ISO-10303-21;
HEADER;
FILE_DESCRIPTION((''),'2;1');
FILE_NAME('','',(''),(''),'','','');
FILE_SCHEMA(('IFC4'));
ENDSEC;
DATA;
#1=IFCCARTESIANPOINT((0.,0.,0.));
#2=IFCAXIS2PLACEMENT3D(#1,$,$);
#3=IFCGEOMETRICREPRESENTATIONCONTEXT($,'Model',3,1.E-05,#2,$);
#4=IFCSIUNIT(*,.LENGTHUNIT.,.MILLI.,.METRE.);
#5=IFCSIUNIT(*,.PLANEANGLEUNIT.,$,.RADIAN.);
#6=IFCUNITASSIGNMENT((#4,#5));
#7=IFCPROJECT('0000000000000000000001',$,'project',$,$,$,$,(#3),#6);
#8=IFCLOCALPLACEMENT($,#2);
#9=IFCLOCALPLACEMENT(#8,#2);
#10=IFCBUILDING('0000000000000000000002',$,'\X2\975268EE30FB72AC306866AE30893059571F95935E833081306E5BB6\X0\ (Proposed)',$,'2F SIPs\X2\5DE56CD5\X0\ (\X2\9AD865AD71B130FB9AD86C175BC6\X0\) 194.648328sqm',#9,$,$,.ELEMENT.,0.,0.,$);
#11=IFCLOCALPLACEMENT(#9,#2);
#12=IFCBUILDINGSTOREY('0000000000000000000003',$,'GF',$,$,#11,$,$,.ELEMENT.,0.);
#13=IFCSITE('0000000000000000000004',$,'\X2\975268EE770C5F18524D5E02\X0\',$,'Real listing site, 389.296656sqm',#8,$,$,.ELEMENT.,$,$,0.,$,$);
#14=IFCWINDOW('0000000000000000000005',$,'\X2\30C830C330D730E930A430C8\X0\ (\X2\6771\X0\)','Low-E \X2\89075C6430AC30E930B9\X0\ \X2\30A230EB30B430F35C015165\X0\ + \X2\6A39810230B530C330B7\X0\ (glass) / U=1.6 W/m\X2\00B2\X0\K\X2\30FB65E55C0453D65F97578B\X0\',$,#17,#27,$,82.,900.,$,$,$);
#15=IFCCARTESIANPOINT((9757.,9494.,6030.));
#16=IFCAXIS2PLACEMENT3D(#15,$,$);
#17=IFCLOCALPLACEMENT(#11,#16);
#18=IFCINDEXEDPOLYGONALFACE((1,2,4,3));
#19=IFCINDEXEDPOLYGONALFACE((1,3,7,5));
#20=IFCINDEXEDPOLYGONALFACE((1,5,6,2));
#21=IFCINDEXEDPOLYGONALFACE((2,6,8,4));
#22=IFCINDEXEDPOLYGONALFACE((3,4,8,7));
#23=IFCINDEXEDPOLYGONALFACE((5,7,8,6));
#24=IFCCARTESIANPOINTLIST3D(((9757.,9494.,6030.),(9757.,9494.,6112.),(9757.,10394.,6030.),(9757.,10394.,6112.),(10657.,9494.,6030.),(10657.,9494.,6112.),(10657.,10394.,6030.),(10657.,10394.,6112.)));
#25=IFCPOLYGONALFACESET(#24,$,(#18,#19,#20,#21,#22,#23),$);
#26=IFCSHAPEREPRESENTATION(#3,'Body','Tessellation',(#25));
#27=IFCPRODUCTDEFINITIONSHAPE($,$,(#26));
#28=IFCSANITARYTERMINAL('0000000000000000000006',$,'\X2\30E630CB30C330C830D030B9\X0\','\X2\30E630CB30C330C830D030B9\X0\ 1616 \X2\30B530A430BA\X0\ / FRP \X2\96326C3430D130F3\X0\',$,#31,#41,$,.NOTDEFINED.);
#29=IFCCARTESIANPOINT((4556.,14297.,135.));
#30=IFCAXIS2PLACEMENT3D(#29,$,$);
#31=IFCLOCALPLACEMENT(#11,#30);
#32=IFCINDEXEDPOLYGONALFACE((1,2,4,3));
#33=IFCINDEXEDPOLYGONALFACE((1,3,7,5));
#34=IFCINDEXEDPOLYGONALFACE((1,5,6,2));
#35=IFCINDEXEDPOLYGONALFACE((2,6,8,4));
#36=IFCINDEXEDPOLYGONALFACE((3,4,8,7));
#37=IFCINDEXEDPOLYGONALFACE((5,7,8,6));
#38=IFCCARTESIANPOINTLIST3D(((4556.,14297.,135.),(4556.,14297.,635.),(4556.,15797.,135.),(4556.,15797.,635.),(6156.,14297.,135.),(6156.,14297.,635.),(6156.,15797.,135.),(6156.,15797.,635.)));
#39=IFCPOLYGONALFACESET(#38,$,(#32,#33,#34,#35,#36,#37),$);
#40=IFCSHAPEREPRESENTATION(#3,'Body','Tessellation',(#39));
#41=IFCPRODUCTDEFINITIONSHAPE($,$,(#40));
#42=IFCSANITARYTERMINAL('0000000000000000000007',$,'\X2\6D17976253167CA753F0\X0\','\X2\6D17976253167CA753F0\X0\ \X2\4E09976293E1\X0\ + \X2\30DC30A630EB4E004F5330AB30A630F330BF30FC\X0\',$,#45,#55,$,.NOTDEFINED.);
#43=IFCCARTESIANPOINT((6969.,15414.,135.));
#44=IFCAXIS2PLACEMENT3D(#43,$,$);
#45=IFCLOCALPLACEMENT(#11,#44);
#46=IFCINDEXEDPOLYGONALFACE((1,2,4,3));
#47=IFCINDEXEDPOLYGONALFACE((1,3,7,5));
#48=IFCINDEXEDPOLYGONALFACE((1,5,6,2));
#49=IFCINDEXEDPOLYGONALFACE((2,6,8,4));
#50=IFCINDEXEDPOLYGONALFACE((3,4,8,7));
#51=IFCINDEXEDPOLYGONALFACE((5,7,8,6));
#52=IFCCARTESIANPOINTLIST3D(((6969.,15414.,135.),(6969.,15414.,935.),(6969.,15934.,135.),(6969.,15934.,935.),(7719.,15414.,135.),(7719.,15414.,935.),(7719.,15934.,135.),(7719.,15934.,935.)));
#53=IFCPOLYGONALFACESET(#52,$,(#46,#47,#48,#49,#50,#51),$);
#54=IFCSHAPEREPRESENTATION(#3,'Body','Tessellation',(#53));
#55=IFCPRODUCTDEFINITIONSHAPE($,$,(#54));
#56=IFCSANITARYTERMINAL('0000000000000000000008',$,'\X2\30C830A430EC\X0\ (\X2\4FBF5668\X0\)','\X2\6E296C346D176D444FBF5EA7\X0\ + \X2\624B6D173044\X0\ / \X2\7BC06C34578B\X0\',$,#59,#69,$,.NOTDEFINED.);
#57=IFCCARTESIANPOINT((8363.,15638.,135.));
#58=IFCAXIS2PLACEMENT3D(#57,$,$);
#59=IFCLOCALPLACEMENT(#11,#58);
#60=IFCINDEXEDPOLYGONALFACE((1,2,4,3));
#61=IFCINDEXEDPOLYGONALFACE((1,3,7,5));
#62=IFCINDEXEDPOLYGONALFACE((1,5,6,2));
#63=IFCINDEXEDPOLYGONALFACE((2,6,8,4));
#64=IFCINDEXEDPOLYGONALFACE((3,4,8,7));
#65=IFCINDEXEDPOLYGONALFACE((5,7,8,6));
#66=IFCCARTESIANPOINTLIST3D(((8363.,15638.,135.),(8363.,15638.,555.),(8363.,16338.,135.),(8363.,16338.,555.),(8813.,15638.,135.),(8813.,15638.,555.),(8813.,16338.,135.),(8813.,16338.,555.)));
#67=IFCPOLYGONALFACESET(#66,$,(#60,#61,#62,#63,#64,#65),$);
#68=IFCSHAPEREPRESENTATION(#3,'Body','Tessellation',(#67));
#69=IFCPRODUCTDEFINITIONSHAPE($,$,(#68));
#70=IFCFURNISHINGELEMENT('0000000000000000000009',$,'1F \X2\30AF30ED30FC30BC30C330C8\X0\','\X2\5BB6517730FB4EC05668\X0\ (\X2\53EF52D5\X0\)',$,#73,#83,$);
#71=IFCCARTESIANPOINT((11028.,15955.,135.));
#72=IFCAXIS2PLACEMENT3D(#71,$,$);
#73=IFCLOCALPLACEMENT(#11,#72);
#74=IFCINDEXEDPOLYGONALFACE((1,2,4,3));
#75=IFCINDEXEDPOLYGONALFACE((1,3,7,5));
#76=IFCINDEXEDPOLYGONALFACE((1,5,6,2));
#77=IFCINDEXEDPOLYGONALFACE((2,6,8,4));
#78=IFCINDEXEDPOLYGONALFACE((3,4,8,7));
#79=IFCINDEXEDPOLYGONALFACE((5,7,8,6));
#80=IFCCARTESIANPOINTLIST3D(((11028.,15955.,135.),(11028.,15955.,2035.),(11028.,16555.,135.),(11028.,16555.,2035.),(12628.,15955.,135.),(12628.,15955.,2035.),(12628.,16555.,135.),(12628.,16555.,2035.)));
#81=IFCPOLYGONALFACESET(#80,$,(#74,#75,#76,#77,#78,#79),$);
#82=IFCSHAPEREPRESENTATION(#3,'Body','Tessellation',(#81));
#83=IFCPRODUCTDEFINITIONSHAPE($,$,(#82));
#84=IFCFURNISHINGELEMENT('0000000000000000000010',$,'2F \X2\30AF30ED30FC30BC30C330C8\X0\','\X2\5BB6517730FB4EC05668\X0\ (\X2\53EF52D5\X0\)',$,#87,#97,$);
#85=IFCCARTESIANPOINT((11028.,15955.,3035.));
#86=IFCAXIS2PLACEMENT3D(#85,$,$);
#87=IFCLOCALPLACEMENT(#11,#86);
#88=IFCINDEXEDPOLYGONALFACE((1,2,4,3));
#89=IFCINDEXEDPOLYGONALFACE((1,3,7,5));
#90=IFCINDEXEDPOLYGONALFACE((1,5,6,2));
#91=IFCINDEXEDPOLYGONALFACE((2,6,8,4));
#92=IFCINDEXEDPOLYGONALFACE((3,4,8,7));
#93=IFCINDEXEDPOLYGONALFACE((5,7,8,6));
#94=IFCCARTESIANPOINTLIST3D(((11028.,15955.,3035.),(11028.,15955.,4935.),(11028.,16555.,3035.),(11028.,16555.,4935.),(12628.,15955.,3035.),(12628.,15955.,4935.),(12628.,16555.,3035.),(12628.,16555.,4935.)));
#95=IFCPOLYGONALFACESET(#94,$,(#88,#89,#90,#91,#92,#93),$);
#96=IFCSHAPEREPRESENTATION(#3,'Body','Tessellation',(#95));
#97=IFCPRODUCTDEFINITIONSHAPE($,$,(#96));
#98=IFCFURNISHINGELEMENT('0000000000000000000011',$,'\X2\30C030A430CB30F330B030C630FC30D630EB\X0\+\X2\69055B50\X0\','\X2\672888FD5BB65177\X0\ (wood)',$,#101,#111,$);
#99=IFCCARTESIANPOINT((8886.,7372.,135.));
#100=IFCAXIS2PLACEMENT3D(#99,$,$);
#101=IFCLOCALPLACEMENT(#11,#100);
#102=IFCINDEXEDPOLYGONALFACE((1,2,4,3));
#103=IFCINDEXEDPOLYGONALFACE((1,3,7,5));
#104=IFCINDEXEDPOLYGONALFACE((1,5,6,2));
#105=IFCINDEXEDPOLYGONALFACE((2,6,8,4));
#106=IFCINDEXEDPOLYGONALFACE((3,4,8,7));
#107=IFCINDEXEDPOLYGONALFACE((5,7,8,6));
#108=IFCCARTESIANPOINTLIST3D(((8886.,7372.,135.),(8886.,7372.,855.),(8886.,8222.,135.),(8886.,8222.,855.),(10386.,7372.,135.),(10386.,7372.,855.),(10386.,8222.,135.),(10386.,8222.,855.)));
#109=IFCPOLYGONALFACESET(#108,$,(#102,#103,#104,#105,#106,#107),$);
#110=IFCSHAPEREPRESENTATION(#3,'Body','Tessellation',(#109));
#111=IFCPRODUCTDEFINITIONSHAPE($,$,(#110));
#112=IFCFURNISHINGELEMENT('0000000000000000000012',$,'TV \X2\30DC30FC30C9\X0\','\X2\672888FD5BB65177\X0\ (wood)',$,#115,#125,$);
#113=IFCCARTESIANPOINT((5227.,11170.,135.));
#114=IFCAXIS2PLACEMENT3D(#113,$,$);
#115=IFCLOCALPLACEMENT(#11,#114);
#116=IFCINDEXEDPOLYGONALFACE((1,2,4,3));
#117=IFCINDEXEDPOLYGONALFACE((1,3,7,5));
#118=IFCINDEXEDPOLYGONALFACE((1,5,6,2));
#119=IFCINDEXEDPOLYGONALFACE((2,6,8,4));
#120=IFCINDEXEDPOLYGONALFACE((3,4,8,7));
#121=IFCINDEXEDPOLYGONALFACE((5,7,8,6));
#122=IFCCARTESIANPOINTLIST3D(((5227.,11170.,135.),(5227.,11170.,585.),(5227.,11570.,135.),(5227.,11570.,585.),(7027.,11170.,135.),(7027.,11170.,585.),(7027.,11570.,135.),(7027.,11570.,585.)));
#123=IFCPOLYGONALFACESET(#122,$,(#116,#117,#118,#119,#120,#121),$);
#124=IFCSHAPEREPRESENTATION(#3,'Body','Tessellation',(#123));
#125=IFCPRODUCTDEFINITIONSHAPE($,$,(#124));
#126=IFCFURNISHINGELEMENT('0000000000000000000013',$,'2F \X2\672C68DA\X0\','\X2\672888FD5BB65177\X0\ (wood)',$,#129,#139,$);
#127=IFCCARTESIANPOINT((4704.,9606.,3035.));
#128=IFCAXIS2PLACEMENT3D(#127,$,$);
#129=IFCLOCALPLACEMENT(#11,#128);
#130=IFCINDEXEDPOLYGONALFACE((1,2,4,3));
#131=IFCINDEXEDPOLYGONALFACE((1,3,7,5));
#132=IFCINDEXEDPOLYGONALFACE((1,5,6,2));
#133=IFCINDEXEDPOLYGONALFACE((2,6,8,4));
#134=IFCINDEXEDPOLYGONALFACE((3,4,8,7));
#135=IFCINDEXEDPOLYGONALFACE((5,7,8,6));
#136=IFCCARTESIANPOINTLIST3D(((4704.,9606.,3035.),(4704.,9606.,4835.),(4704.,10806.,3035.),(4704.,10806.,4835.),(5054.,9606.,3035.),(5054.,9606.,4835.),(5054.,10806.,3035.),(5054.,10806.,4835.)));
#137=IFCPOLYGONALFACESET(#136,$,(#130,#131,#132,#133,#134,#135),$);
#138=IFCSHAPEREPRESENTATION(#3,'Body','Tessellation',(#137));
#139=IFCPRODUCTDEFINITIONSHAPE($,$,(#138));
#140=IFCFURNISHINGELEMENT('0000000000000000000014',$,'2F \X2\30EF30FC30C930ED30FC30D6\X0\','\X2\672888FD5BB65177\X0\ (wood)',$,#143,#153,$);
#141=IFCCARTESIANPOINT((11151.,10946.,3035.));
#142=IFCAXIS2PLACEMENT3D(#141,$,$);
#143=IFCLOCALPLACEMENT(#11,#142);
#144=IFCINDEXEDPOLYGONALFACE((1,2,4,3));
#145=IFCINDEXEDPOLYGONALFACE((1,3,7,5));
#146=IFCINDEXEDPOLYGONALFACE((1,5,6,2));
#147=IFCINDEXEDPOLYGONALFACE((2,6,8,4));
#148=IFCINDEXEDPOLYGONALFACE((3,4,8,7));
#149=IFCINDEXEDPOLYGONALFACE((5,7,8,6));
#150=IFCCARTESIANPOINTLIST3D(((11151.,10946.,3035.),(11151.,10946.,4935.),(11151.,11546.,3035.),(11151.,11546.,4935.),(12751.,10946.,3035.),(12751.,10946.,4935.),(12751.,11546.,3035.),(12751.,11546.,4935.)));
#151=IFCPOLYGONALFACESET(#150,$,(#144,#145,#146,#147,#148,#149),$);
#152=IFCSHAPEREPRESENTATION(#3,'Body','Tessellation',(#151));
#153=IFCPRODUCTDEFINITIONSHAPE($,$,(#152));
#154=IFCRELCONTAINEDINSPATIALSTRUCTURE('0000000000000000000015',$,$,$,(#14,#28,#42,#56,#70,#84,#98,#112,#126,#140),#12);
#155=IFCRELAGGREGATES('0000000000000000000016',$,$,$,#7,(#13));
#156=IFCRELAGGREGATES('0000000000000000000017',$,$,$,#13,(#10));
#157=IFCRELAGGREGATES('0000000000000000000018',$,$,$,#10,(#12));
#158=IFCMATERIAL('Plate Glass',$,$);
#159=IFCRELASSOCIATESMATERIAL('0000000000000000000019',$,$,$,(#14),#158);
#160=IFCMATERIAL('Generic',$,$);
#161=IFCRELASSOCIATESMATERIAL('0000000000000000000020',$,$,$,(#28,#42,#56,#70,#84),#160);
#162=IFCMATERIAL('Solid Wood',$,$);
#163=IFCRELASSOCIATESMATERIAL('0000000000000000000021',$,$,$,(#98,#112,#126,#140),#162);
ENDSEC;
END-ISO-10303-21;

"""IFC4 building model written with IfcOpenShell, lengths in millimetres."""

from ifc_helpers import new_model, si_unit, frame, frame_2d, origin, place, context, project, spatial, rectangle, extrude, material, element, save


model = new_model("IFC4")

# Units and contexts
model_context = context("Model", 3, precision=1e-05, world=origin())
ifc_project = project(units=[si_unit("LENGTHUNIT", "METRE", prefix="MILLI"), si_unit("PLANEANGLEUNIT", "RADIAN")], contexts=[model_context])

# Site, building, storey
site_placement = place(None, origin())
site = spatial("IfcSite", under=ifc_project, at=site_placement, Name="青森県弘前市", ObjectType="Real listing site, 389.296656sqm", CompositionType="ELEMENT", RefElevation=0.0)
building_placement = place(site_placement, origin())
building = spatial("IfcBuilding", under=site, at=building_placement, Name="青森・犬と暮らす土間広めの家 (Proposed)", ObjectType="2F SIPs工法 (高断熱・高気密) 194.648328sqm", CompositionType="ELEMENT", ElevationOfRefHeight=0.0, ElevationOfTerrain=0.0)
storey_placement = place(building_placement, origin())
storey = spatial("IfcBuildingStorey", under=building, at=storey_placement, Name="GF", CompositionType="ELEMENT", Elevation=0.0)

# Shared definitions
ifc_material_1 = material(Name="Solid Wood")
ifc_material_2 = material(Name="Plate Glass")

# Window
window_1_placement = place(storey_placement, frame((9757.0, 9494.0, 6030.0)))
element("IfcWindow", 1, at=window_1_placement, inside=storey, material=ifc_material_2, Name="トップライト (東)", Description="Low-E 複層ガラス アルゴン封入 + 樹脂サッシ (glass) / U=1.6 W/m²K・日射取得型", OverallHeight=82.0, OverallWidth=900.0, context=model_context, shape_type="SweptSolid", body=[
    extrude(rectangle(XDim=900.0, YDim=900.0, at=frame_2d((450.0, 450.0))), frame((9757.0, 9494.0, 6030.0)), (0.0, 0.0, 1.0), 82.0),
])

# Sanitary terminals
ifc_material_3 = material(Name="Generic")
sanitary_terminal_1_placement = place(storey_placement, frame((4556.0, 14297.0, 135.0)))
element("IfcSanitaryTerminal", 2, at=sanitary_terminal_1_placement, inside=storey, material=ifc_material_3, Name="ユニットバス", Description="ユニットバス 1616 サイズ / FRP 防水パン", PredefinedType="NOTDEFINED", context=model_context, shape_type="SweptSolid", body=[
    extrude(rectangle(XDim=1600.0, YDim=1500.0, at=frame_2d((800.0, 750.0))), frame((4556.0, 14297.0, 135.0)), (0.0, 0.0, 1.0), 500.0),
])
sanitary_terminal_2_placement = place(storey_placement, frame((6969.0, 15414.0, 135.0)))
element("IfcSanitaryTerminal", 3, at=sanitary_terminal_2_placement, inside=storey, material=ifc_material_3, Name="洗面化粧台", Description="洗面化粧台 三面鏡 + ボウル一体カウンター", PredefinedType="NOTDEFINED", context=model_context, shape_type="SweptSolid", body=[
    extrude(rectangle(XDim=750.0, YDim=520.0, at=frame_2d((375.0, 260.0))), frame((6969.0, 15414.0, 135.0)), (0.0, 0.0, 1.0), 800.0),
])
sanitary_terminal_3_placement = place(storey_placement, frame((8363.0, 15638.0, 135.0)))
element("IfcSanitaryTerminal", 4, at=sanitary_terminal_3_placement, inside=storey, material=ifc_material_3, Name="トイレ (便器)", Description="温水洗浄便座 + 手洗い / 節水型", PredefinedType="NOTDEFINED", context=model_context, shape_type="SweptSolid", body=[
    extrude(rectangle(XDim=450.0, YDim=700.0, at=frame_2d((225.0, 350.0))), frame((8363.0, 15638.0, 135.0)), (0.0, 0.0, 1.0), 420.0),
])

# Furnishing elements
furnishing_1_placement = place(storey_placement, frame((11028.0, 15955.0, 135.0)))
element("IfcFurnishingElement", 5, at=furnishing_1_placement, inside=storey, material=ifc_material_3, Name="1F クローゼット", Description="家具・什器 (可動)", context=model_context, shape_type="SweptSolid", body=[
    extrude(rectangle(XDim=1600.0, YDim=600.0, at=frame_2d((800.0, 300.0))), frame((11028.0, 15955.0, 135.0)), (0.0, 0.0, 1.0), 1900.0),
])
furnishing_2_placement = place(storey_placement, frame((11028.0, 15955.0, 3035.0)))
element("IfcFurnishingElement", 6, at=furnishing_2_placement, inside=storey, material=ifc_material_3, Name="2F クローゼット", Description="家具・什器 (可動)", context=model_context, shape_type="SweptSolid", body=[
    extrude(rectangle(XDim=1600.0, YDim=600.0, at=frame_2d((800.0, 300.0))), frame((11028.0, 15955.0, 3035.0)), (0.0, 0.0, 1.0), 1900.0),
])
furnishing_3_placement = place(storey_placement, frame((8886.0, 7372.0, 135.0)))
element("IfcFurnishingElement", 7, at=furnishing_3_placement, inside=storey, material=ifc_material_1, Name="ダイニングテーブル+椅子", Description="木製家具 (wood)", context=model_context, shape_type="SweptSolid", body=[
    extrude(rectangle(XDim=1500.0, YDim=850.0, at=frame_2d((750.0, 425.0))), frame((8886.0, 7372.0, 135.0)), (0.0, 0.0, 1.0), 720.0),
])
furnishing_4_placement = place(storey_placement, frame((5227.0, 11170.0, 135.0)))
element("IfcFurnishingElement", 8, at=furnishing_4_placement, inside=storey, material=ifc_material_1, Name="TV ボード", Description="木製家具 (wood)", context=model_context, shape_type="SweptSolid", body=[
    extrude(rectangle(XDim=1800.0, YDim=400.0, at=frame_2d((900.0, 200.0))), frame((5227.0, 11170.0, 135.0)), (0.0, 0.0, 1.0), 450.0),
])
furnishing_5_placement = place(storey_placement, frame((4704.0, 9606.0, 3035.0)))
element("IfcFurnishingElement", 9, at=furnishing_5_placement, inside=storey, material=ifc_material_1, Name="2F 本棚", Description="木製家具 (wood)", context=model_context, shape_type="SweptSolid", body=[
    extrude(rectangle(XDim=350.0, YDim=1200.0, at=frame_2d((175.0, 600.0))), frame((4704.0, 9606.0, 3035.0)), (0.0, 0.0, 1.0), 1800.0),
])
furnishing_6_placement = place(storey_placement, frame((11151.0, 10946.0, 3035.0)))
element("IfcFurnishingElement", 10, at=furnishing_6_placement, inside=storey, material=ifc_material_1, Name="2F ワードローブ", Description="木製家具 (wood)", context=model_context, shape_type="SweptSolid", body=[
    extrude(rectangle(XDim=1600.0, YDim=600.0, at=frame_2d((800.0, 300.0))), frame((11151.0, 10946.0, 3035.0)), (0.0, 0.0, 1.0), 1900.0),
])

save(model, "model.ifc")
